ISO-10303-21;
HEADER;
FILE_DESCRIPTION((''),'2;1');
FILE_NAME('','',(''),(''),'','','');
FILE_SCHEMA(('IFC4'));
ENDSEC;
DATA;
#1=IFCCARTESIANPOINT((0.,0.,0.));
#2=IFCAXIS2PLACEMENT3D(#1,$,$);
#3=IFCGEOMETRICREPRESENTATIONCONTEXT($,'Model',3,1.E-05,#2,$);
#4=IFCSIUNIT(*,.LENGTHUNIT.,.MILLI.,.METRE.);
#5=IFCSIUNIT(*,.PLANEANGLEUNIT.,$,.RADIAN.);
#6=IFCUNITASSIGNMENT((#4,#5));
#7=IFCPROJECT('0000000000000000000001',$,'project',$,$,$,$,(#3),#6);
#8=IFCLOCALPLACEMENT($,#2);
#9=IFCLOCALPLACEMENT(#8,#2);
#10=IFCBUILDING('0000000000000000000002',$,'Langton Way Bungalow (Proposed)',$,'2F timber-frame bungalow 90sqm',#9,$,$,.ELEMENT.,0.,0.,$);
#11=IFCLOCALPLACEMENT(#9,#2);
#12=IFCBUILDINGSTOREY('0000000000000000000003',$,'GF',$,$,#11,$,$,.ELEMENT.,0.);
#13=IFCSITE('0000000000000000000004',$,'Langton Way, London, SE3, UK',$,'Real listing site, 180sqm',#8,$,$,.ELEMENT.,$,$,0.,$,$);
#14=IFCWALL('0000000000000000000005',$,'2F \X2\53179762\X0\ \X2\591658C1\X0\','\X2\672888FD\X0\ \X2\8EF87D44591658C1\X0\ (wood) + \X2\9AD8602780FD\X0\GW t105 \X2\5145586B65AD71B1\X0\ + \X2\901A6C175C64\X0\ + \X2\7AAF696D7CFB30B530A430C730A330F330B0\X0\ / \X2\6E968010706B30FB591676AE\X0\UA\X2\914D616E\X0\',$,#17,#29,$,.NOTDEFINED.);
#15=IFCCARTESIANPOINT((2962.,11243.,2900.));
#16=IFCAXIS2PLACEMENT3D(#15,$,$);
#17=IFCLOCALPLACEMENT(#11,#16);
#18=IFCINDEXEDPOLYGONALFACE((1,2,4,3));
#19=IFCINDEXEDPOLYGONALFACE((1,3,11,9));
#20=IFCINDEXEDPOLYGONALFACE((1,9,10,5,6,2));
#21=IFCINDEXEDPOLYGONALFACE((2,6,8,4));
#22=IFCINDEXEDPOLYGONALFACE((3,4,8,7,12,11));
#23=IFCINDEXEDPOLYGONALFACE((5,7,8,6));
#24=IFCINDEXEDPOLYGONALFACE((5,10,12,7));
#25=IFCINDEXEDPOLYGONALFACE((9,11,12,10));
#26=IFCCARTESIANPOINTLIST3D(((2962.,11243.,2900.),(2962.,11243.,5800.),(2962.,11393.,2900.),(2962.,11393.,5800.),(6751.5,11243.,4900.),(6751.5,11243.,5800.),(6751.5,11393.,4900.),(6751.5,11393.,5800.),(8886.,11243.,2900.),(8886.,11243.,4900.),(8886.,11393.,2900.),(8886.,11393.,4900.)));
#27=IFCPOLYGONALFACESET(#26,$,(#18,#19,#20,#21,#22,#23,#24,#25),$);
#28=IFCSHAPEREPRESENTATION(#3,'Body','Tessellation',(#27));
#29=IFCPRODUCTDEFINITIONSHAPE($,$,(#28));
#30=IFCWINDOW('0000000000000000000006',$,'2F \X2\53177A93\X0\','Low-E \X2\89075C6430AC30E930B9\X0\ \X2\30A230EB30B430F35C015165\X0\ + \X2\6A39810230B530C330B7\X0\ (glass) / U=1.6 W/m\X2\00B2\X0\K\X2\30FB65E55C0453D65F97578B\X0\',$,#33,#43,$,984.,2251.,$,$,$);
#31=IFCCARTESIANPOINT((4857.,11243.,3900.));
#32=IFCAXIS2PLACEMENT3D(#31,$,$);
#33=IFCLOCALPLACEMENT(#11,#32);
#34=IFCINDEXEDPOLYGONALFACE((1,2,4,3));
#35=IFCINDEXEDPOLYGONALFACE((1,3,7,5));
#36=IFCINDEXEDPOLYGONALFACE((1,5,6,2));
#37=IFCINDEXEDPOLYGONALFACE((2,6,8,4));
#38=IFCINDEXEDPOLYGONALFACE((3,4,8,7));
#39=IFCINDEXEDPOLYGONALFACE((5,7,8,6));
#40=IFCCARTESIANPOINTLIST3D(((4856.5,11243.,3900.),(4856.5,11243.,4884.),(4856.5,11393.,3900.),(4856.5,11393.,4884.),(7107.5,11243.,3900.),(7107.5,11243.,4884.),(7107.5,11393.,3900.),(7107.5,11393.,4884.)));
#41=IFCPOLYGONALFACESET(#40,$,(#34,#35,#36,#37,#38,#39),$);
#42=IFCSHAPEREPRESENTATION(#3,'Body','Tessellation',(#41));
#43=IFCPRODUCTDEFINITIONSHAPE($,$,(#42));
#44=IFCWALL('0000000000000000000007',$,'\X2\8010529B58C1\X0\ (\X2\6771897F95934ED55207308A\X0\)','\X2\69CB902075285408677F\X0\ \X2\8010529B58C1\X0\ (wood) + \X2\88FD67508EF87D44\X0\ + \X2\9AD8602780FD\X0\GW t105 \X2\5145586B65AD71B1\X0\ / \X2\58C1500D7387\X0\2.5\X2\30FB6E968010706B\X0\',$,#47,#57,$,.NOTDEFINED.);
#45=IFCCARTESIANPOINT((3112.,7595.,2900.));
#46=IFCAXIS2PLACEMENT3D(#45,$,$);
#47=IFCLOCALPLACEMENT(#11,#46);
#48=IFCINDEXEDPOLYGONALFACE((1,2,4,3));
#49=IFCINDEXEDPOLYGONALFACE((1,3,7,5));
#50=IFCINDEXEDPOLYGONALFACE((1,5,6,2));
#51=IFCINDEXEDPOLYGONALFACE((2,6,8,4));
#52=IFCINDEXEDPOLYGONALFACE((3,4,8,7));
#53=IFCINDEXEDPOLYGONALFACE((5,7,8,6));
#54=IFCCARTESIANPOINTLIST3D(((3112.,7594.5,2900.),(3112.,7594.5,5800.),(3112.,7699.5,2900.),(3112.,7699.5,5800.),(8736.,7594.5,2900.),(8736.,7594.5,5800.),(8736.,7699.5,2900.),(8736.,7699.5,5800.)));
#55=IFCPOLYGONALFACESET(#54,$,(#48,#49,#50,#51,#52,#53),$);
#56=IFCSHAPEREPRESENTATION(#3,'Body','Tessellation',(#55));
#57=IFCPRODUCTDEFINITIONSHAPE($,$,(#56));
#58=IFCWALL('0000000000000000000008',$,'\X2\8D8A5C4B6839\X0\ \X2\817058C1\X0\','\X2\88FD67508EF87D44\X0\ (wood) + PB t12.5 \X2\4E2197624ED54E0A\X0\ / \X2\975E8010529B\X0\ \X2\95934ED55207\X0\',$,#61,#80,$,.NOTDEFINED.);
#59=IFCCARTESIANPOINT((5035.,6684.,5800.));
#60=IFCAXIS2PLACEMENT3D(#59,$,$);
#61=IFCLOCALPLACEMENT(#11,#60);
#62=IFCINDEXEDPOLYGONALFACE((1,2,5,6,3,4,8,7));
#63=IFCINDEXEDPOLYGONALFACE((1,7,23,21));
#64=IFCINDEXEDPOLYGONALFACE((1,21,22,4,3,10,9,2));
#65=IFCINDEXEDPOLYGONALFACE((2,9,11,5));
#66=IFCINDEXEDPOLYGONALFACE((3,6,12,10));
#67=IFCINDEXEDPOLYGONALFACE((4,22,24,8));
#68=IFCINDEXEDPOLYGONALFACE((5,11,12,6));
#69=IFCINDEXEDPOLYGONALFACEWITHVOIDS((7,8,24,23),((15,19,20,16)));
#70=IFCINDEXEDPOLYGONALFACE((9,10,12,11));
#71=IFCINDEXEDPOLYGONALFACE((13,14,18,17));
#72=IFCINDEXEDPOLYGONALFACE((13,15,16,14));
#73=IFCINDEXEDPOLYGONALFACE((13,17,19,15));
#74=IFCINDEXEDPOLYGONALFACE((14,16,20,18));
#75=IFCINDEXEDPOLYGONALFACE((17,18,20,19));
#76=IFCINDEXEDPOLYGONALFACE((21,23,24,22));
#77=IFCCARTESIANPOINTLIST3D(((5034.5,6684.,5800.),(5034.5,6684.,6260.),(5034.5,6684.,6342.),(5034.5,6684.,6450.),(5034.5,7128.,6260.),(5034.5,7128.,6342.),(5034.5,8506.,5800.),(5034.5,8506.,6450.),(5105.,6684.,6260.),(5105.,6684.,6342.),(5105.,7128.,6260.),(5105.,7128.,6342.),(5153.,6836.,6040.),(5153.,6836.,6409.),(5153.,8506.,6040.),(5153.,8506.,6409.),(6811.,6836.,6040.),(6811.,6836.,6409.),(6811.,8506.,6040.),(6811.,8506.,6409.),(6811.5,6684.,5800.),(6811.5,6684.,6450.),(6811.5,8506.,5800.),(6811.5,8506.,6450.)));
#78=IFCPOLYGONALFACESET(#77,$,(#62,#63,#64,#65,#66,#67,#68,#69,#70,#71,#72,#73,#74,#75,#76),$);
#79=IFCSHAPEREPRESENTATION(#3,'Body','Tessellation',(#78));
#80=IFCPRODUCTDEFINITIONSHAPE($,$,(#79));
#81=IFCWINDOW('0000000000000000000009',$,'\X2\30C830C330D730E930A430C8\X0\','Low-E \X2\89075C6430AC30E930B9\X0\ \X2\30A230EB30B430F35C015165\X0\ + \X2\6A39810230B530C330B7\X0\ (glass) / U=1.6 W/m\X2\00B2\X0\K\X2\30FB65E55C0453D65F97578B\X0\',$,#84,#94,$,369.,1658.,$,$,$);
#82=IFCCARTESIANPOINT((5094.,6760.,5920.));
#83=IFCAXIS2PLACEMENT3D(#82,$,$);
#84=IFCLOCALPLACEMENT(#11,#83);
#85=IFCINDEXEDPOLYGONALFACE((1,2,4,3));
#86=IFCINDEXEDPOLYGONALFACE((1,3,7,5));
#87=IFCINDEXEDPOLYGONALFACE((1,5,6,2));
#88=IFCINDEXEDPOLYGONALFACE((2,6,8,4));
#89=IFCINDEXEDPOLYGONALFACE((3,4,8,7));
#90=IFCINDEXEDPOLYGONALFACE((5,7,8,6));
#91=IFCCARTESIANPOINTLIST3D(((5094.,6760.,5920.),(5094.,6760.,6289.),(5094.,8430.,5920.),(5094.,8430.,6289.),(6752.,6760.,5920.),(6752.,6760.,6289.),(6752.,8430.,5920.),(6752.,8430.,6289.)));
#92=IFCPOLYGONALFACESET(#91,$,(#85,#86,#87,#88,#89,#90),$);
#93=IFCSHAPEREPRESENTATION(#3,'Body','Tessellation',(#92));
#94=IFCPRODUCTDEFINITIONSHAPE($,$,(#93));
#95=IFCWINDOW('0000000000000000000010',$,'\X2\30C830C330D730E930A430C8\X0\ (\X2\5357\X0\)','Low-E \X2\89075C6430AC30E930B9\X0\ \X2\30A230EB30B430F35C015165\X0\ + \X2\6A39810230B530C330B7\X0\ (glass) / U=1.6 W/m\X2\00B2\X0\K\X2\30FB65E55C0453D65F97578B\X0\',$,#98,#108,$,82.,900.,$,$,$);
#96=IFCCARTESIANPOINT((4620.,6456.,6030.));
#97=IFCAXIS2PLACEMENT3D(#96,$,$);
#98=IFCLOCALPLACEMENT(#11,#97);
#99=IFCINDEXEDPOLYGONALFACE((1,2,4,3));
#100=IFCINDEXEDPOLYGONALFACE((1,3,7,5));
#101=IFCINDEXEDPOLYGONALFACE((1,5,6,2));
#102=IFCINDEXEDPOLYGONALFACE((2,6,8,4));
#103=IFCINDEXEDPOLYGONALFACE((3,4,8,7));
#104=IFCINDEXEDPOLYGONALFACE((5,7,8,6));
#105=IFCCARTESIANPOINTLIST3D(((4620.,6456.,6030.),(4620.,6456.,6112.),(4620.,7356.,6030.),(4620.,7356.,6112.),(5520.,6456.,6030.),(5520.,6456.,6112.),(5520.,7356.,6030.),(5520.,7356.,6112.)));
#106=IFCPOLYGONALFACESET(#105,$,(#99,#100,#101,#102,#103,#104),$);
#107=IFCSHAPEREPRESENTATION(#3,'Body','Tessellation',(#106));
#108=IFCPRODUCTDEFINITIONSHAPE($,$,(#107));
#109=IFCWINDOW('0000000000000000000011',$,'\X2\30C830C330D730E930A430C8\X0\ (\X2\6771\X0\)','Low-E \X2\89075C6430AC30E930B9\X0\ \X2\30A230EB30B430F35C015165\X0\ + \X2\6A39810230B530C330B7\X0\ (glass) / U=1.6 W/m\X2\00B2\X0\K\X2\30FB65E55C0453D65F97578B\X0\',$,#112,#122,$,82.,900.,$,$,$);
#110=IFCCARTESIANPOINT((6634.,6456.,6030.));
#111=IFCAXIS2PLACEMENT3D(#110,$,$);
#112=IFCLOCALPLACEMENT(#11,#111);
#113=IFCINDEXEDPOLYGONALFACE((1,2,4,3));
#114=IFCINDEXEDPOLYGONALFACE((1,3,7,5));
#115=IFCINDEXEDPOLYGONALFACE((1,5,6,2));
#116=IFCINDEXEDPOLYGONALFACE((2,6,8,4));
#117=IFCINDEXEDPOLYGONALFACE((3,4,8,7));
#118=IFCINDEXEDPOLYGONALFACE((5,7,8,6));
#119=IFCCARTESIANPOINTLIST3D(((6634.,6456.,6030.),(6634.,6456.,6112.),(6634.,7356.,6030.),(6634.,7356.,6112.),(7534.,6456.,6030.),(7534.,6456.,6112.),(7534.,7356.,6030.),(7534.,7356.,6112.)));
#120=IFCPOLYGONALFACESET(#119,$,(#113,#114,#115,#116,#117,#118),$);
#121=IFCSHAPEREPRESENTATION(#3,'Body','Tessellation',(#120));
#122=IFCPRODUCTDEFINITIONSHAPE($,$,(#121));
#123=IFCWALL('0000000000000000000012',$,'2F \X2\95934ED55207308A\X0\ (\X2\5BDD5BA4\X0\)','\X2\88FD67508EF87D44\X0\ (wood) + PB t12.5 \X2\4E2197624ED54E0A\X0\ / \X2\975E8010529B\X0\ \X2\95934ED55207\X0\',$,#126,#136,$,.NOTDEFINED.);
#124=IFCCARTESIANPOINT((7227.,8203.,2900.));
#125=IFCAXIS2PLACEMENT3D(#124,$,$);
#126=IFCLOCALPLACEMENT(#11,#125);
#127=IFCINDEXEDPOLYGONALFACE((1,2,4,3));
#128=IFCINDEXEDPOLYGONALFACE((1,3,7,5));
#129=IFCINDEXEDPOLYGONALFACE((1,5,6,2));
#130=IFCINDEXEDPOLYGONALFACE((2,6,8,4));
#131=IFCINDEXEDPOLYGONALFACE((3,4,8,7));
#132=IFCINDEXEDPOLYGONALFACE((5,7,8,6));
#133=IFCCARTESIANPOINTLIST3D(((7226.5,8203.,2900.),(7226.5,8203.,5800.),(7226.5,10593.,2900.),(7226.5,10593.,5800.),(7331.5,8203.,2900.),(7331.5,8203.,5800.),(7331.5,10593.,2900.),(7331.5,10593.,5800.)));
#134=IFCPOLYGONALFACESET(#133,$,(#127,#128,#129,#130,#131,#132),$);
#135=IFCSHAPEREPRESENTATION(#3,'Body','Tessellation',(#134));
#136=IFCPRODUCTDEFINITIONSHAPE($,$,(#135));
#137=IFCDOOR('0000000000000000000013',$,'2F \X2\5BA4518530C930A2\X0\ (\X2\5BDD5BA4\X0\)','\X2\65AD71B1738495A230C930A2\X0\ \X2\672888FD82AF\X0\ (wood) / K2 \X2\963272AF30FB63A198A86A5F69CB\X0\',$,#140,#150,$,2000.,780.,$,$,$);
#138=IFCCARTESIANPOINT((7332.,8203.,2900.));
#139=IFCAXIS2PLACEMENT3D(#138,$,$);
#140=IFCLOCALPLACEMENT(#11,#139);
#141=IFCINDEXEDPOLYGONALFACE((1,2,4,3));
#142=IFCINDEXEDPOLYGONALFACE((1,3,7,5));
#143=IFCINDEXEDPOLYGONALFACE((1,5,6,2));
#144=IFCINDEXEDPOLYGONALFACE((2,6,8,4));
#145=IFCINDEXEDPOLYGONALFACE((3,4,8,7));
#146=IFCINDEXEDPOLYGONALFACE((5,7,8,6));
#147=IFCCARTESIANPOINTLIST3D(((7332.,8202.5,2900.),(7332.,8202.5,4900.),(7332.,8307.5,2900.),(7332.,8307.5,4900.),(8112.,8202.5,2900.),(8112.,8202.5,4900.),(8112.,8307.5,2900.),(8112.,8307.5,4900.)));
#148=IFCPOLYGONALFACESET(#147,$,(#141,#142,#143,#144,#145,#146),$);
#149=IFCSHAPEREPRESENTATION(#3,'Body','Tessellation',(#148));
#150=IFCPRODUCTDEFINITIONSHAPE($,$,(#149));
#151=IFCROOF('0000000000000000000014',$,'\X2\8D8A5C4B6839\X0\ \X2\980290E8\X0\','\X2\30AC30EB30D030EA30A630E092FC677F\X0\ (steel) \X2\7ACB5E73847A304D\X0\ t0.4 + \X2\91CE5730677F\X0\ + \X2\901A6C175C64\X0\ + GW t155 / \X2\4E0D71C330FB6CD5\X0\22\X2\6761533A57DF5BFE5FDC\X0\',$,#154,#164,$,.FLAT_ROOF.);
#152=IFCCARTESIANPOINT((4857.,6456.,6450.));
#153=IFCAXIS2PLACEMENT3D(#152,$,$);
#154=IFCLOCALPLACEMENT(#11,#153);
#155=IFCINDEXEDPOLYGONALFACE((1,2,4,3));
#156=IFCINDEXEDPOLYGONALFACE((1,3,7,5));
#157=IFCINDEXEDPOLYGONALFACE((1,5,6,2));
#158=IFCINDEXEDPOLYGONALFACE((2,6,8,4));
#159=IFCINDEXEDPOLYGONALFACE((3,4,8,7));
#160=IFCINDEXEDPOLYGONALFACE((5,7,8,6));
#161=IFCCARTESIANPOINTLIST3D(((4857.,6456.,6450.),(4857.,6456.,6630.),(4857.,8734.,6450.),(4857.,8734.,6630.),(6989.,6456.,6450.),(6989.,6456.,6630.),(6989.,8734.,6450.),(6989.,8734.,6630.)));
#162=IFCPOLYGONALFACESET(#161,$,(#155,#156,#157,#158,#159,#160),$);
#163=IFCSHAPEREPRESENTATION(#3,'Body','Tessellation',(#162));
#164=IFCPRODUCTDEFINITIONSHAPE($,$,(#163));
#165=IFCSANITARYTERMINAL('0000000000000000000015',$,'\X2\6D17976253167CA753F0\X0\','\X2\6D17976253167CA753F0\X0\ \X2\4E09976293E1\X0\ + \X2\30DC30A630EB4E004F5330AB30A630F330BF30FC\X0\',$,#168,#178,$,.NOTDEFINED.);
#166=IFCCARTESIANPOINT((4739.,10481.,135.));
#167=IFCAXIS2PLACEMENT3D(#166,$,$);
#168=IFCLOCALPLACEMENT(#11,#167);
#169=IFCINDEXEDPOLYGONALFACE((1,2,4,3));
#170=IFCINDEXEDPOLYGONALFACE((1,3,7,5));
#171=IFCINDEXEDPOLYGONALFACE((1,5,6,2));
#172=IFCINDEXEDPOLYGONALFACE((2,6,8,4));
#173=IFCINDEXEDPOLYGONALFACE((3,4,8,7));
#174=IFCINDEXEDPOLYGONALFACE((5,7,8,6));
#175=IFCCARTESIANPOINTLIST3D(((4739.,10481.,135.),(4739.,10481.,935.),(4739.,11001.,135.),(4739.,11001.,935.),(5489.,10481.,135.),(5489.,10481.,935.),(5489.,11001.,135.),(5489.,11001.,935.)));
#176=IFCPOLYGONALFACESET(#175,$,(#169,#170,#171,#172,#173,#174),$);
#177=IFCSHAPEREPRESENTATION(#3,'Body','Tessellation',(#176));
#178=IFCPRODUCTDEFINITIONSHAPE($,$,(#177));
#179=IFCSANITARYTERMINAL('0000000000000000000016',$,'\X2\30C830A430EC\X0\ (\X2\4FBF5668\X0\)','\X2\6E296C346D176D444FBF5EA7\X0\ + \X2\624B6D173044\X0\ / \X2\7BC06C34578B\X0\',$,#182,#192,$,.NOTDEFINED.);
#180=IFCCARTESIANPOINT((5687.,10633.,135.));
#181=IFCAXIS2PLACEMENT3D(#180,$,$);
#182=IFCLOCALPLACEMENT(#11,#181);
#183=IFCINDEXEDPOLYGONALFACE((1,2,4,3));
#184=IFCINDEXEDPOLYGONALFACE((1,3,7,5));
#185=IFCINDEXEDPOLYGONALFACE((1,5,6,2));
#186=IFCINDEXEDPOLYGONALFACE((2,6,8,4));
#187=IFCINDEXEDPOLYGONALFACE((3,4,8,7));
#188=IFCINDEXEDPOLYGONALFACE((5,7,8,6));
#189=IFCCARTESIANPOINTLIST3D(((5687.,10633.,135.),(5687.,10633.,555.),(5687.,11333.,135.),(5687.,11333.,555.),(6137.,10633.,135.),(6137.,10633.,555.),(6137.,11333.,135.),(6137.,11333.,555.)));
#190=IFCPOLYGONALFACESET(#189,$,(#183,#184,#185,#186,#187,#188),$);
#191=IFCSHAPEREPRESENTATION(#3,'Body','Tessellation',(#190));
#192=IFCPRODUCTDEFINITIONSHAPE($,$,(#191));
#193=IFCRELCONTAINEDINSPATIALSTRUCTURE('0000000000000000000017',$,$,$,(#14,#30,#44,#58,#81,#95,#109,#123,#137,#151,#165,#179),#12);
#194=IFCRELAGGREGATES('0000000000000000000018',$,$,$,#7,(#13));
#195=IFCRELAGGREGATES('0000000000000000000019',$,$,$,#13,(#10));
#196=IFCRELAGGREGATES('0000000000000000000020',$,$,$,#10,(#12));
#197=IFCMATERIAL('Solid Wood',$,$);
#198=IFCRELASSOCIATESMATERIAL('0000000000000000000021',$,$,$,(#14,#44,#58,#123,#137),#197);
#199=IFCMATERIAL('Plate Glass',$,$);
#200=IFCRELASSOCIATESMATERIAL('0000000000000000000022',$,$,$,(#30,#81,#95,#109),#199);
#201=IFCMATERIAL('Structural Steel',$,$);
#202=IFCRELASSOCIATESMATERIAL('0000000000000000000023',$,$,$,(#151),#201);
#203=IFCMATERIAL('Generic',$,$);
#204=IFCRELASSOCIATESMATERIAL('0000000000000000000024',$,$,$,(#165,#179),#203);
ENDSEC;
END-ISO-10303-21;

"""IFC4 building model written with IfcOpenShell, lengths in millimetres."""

from ifc_helpers import new_model, si_unit, frame, frame_2d, origin, place, context, project, spatial, rectangle, extrude, material, element, fill, save


model = new_model("IFC4")

# Units and contexts
model_context = context("Model", 3, precision=1e-05, world=origin())
ifc_project = project(units=[si_unit("LENGTHUNIT", "METRE", prefix="MILLI"), si_unit("PLANEANGLEUNIT", "RADIAN")], contexts=[model_context])

# Site, building, storey
site_placement = place(None, origin())
site = spatial("IfcSite", under=ifc_project, at=site_placement, Name="Langton Way, London, SE3, UK", ObjectType="Real listing site, 180sqm", CompositionType="ELEMENT", RefElevation=0.0)
building_placement = place(site_placement, origin())
building = spatial("IfcBuilding", under=site, at=building_placement, Name="Langton Way Bungalow (Proposed)", ObjectType="2F timber-frame bungalow 90sqm", CompositionType="ELEMENT", ElevationOfRefHeight=0.0, ElevationOfTerrain=0.0)
storey_placement = place(building_placement, origin())
storey = spatial("IfcBuildingStorey", under=building, at=storey_placement, Name="GF", CompositionType="ELEMENT", Elevation=0.0)

# Wall, opening, window
ifc_material_1 = material(Name="Solid Wood")
wall_1_placement = place(storey_placement, frame((2962.0, 11243.0, 2900.0)))
wall_1 = element("IfcWall", 1, at=wall_1_placement, inside=storey, material=ifc_material_1, Name="2F 北面 外壁", Description="木製 軸組外壁 (wood) + 高性能GW t105 充填断熱 + 通気層 + 窯業系サイディング / 準耐火・外皮UA配慮", PredefinedType="NOTDEFINED", context=model_context, shape_type="SweptSolid", body=[
    extrude(rectangle(XDim=5924.0, YDim=150.0, at=frame_2d((2962.0, 75.0))), frame((2962.0, 11243.0, 2900.0)), (0.0, 0.0, 1.0), 2900.0),
])
opening_1_placement = place(storey_placement, frame((4857.0, 11243.0, 3900.0)))
opening_1 = element("IfcOpeningElement", 2, at=opening_1_placement, cuts=wall_1, PredefinedType="NOTDEFINED", context=model_context, shape_type="SweptSolid", body=[
    extrude(rectangle(XDim=2251.0, YDim=150.0, at=frame_2d((1125.0, 75.0))), frame((4857.0, 11243.0, 3900.0)), (0.0, 0.0, 1.0), 984.0),
])
ifc_material_2 = material(Name="Plate Glass")
window_1_placement = place(storey_placement, frame((4857.0, 11243.0, 3900.0)))
window_1 = element("IfcWindow", 3, at=window_1_placement, inside=storey, material=ifc_material_2, Name="2F 北窓", Description="Low-E 複層ガラス アルゴン封入 + 樹脂サッシ (glass) / U=1.6 W/m²K・日射取得型", OverallHeight=984.0, OverallWidth=2251.0, context=model_context, shape_type="SweptSolid", body=[
    extrude(rectangle(XDim=2251.0, YDim=150.0, at=frame_2d((1125.0, 75.0))), frame((4857.0, 11243.0, 3900.0)), (0.0, 0.0, 1.0), 984.0),
])
fill(opening_1, window_1)

# Wall
wall_2_placement = place(storey_placement, frame((3112.0, 7595.0, 2900.0)))
element("IfcWall", 4, at=wall_2_placement, inside=storey, material=ifc_material_1, Name="耐力壁 (東西間仕切り)", Description="構造用合板 耐力壁 (wood) + 製材軸組 + 高性能GW t105 充填断熱 / 壁倍率2.5・準耐火", PredefinedType="NOTDEFINED", context=model_context, shape_type="SweptSolid", body=[
    extrude(rectangle(XDim=5624.0, YDim=105.0, at=frame_2d((2812.0, 52.0))), frame((3112.0, 7595.0, 2900.0)), (0.0, 0.0, 1.0), 2900.0),
])

# Wall, openings, windows
wall_3_placement = place(storey_placement, frame((5035.0, 6684.0, 5800.0)))
wall_3 = element("IfcWall", 5, at=wall_3_placement, inside=storey, material=ifc_material_1, Name="越屋根 腰壁", Description="製材軸組 (wood) + PB t12.5 両面仕上 / 非耐力 間仕切", PredefinedType="NOTDEFINED", context=model_context, shape_type="SweptSolid", body=[
    extrude(rectangle(XDim=1777.0, YDim=1822.0, at=frame_2d((888.0, 911.0))), frame((5035.0, 6684.0, 5800.0)), (0.0, 0.0, 1.0), 650.0),
])
opening_2_placement = place(storey_placement, frame((5094.0, 6760.0, 5920.0)))
opening_2 = element("IfcOpeningElement", 6, at=opening_2_placement, cuts=wall_3, PredefinedType="NOTDEFINED", context=model_context, shape_type="SweptSolid", body=[
    extrude(rectangle(XDim=1658.0, YDim=1670.0, at=frame_2d((829.0, 835.0))), frame((5094.0, 6760.0, 5920.0)), (0.0, 0.0, 1.0), 369.0),
])
opening_3_placement = place(storey_placement, frame((4620.0, 6456.0, 6030.0)))
opening_3 = element("IfcOpeningElement", 7, at=opening_3_placement, cuts=wall_3, PredefinedType="NOTDEFINED", context=model_context, shape_type="SweptSolid", body=[
    extrude(rectangle(XDim=900.0, YDim=900.0, at=frame_2d((450.0, 450.0))), frame((4620.0, 6456.0, 6030.0)), (0.0, 0.0, 1.0), 82.0),
])
opening_4_placement = place(storey_placement, frame((6634.0, 6456.0, 6030.0)))
opening_4 = element("IfcOpeningElement", 8, at=opening_4_placement, cuts=wall_3, PredefinedType="NOTDEFINED", context=model_context, shape_type="SweptSolid", body=[
    extrude(rectangle(XDim=900.0, YDim=900.0, at=frame_2d((450.0, 450.0))), frame((6634.0, 6456.0, 6030.0)), (0.0, 0.0, 1.0), 82.0),
])
window_2_placement = place(storey_placement, frame((5094.0, 6760.0, 5920.0)))
window_2 = element("IfcWindow", 9, at=window_2_placement, inside=storey, material=ifc_material_2, Name="トップライト", Description="Low-E 複層ガラス アルゴン封入 + 樹脂サッシ (glass) / U=1.6 W/m²K・日射取得型", OverallHeight=369.0, OverallWidth=1658.0, context=model_context, shape_type="SweptSolid", body=[
    extrude(rectangle(XDim=1658.0, YDim=1670.0, at=frame_2d((829.0, 835.0))), frame((5094.0, 6760.0, 5920.0)), (0.0, 0.0, 1.0), 369.0),
])
fill(opening_2, window_2)
window_3_placement = place(storey_placement, frame((4620.0, 6456.0, 6030.0)))
window_3 = element("IfcWindow", 10, at=window_3_placement, inside=storey, material=ifc_material_2, Name="トップライト (南)", Description="Low-E 複層ガラス アルゴン封入 + 樹脂サッシ (glass) / U=1.6 W/m²K・日射取得型", OverallHeight=82.0, OverallWidth=900.0, context=model_context, shape_type="SweptSolid", body=[
    extrude(rectangle(XDim=900.0, YDim=900.0, at=frame_2d((450.0, 450.0))), frame((4620.0, 6456.0, 6030.0)), (0.0, 0.0, 1.0), 82.0),
])
fill(opening_3, window_3)
window_4_placement = place(storey_placement, frame((6634.0, 6456.0, 6030.0)))
window_4 = element("IfcWindow", 11, at=window_4_placement, inside=storey, material=ifc_material_2, Name="トップライト (東)", Description="Low-E 複層ガラス アルゴン封入 + 樹脂サッシ (glass) / U=1.6 W/m²K・日射取得型", OverallHeight=82.0, OverallWidth=900.0, context=model_context, shape_type="SweptSolid", body=[
    extrude(rectangle(XDim=900.0, YDim=900.0, at=frame_2d((450.0, 450.0))), frame((6634.0, 6456.0, 6030.0)), (0.0, 0.0, 1.0), 82.0),
])
fill(opening_4, window_4)

# Wall
wall_4_placement = place(storey_placement, frame((7227.0, 8203.0, 2900.0)))
element("IfcWall", 12, at=wall_4_placement, inside=storey, material=ifc_material_1, Name="2F 間仕切り (寝室)", Description="製材軸組 (wood) + PB t12.5 両面仕上 / 非耐力 間仕切", PredefinedType="NOTDEFINED", context=model_context, shape_type="SweptSolid", body=[
    extrude(rectangle(XDim=105.0, YDim=2390.0, at=frame_2d((52.0, 1195.0))), frame((7227.0, 8203.0, 2900.0)), (0.0, 0.0, 1.0), 2900.0),
])

# Door
door_placement = place(storey_placement, frame((7332.0, 8203.0, 2900.0)))
element("IfcDoor", 13, at=door_placement, inside=storey, material=ifc_material_1, Name="2F 室内ドア (寝室)", Description="断熱玄関ドア 木製芯 (wood) / K2 防犯・採風機構", OverallHeight=2000.0, OverallWidth=780.0, context=model_context, shape_type="SweptSolid", body=[
    extrude(rectangle(XDim=780.0, YDim=105.0, at=frame_2d((390.0, 52.0))), frame((7332.0, 8203.0, 2900.0)), (0.0, 0.0, 1.0), 2000.0),
])

# Roof
ifc_material_3 = material(Name="Structural Steel")
roof_placement = place(storey_placement, frame((4857.0, 6456.0, 6450.0)))
element("IfcRoof", 14, at=roof_placement, inside=storey, material=ifc_material_3, Name="越屋根 頂部", Description="ガルバリウム鋼板 (steel) 立平葺き t0.4 + 野地板 + 通気層 + GW t155 / 不燃・法22条区域対応", PredefinedType="FLAT_ROOF", context=model_context, shape_type="SweptSolid", body=[
    extrude(rectangle(XDim=2132.0, YDim=2278.0, at=frame_2d((1066.0, 1139.0))), frame((4857.0, 6456.0, 6450.0)), (0.0, 0.0, 1.0), 180.0),
])

# Sanitary terminals
ifc_material_4 = material(Name="Generic")
sanitary_terminal_1_placement = place(storey_placement, frame((4739.0, 10481.0, 135.0)))
element("IfcSanitaryTerminal", 15, at=sanitary_terminal_1_placement, inside=storey, material=ifc_material_4, Name="洗面化粧台", Description="洗面化粧台 三面鏡 + ボウル一体カウンター", PredefinedType="NOTDEFINED", context=model_context, shape_type="SweptSolid", body=[
    extrude(rectangle(XDim=750.0, YDim=520.0, at=frame_2d((375.0, 260.0))), frame((4739.0, 10481.0, 135.0)), (0.0, 0.0, 1.0), 800.0),
])
sanitary_terminal_2_placement = place(storey_placement, frame((5687.0, 10633.0, 135.0)))
element("IfcSanitaryTerminal", 16, at=sanitary_terminal_2_placement, inside=storey, material=ifc_material_4, Name="トイレ (便器)", Description="温水洗浄便座 + 手洗い / 節水型", PredefinedType="NOTDEFINED", context=model_context, shape_type="SweptSolid", body=[
    extrude(rectangle(XDim=450.0, YDim=700.0, at=frame_2d((225.0, 350.0))), frame((5687.0, 10633.0, 135.0)), (0.0, 0.0, 1.0), 420.0),
])

save(model, "model.ifc")
